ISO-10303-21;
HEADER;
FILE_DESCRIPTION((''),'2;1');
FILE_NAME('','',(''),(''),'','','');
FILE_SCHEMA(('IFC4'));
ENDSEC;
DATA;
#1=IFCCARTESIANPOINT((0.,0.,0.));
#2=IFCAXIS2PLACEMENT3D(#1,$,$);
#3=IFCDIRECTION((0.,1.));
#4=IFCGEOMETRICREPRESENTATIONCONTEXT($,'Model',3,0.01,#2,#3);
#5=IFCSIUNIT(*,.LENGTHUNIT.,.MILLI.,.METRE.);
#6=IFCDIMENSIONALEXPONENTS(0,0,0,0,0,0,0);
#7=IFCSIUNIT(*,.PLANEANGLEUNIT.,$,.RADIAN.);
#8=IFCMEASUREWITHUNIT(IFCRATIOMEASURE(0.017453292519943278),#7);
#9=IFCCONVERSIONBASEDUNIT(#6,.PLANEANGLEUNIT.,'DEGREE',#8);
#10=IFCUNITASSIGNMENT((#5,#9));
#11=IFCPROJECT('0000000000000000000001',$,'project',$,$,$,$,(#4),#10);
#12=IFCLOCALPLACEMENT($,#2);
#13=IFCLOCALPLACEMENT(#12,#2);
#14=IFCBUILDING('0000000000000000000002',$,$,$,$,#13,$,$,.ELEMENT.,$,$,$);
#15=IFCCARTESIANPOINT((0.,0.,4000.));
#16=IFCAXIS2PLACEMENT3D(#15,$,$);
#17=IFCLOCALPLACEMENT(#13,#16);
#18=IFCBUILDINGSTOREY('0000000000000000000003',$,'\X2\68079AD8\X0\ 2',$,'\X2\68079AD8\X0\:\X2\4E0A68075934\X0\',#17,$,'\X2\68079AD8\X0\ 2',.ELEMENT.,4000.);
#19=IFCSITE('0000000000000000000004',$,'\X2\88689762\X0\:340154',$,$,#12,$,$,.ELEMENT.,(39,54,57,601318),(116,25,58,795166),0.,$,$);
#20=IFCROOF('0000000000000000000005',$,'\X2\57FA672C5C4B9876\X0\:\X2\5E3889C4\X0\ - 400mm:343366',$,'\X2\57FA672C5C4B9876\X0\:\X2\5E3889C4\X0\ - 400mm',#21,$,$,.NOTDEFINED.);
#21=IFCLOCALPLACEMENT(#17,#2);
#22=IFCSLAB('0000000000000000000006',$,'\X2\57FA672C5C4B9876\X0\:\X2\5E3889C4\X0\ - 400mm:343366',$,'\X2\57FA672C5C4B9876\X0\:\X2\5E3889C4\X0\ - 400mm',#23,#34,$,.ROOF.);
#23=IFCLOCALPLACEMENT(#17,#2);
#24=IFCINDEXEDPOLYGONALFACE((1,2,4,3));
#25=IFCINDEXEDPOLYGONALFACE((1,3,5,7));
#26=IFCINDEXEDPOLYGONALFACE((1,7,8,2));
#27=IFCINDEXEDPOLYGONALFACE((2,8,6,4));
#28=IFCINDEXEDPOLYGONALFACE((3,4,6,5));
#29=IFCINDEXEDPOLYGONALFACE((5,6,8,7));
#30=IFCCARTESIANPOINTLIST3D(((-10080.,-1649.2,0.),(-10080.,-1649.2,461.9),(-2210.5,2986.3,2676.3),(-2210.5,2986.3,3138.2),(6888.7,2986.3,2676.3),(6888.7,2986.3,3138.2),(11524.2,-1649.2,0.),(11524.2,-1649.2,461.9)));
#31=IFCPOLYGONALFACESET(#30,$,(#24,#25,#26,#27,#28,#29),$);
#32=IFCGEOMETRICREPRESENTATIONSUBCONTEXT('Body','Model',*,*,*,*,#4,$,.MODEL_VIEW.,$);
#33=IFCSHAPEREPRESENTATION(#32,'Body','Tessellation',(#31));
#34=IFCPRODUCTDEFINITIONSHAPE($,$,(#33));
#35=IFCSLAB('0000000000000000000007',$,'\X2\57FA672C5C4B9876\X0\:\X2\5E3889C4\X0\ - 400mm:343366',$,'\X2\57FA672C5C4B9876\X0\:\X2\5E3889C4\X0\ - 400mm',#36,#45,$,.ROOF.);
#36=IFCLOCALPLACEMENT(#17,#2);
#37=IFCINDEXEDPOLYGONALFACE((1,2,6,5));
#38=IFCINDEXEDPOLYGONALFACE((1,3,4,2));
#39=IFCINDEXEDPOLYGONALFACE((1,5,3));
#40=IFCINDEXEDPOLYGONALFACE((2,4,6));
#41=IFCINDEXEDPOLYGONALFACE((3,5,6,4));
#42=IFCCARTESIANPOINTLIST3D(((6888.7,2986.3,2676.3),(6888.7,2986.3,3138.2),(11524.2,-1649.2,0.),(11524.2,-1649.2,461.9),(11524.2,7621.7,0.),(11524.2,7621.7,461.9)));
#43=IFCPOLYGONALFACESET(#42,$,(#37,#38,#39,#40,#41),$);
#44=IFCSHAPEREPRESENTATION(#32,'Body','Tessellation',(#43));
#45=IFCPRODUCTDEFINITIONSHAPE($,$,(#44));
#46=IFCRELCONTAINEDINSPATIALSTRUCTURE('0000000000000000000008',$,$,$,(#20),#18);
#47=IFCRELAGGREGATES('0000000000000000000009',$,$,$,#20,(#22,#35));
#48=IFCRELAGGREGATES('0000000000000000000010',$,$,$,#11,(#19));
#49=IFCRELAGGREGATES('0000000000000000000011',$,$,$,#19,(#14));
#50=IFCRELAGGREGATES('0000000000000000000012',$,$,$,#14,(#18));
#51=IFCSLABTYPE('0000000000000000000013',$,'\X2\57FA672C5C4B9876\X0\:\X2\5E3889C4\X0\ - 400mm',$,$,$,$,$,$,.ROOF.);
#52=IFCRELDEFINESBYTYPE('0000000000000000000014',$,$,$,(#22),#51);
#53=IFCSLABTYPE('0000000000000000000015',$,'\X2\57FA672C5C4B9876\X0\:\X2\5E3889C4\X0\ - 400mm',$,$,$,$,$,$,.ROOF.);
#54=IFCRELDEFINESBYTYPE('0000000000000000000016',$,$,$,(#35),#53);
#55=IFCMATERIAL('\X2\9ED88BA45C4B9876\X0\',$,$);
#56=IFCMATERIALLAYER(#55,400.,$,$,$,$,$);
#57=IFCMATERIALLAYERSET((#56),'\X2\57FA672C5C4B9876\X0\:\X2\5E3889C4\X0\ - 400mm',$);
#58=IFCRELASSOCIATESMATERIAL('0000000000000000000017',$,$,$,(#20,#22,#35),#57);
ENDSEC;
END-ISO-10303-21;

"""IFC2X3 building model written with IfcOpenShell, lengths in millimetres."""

from ifc_helpers import new_model, entity, si_unit, converted_unit, direction, frame, origin, place, context, subcontext, project, spatial, polyline, outline, extrude, material, layer, layer_set, type_object, element, aggregate, save


model = new_model("IFC2X3")

# Units and contexts
model_context = context("Model", 3, precision=0.01, world=origin(), true_north=direction((0.0, 1.0)))
body_context = subcontext(model_context, "Body", "Model", "MODEL_VIEW")
ifc_project = project(units=[si_unit("LENGTHUNIT", "METRE", prefix="MILLI"), converted_unit("PLANEANGLEUNIT", "DEGREE", entity("IfcRatioMeasure", 0.017453292519943278), si_unit("PLANEANGLEUNIT", "RADIAN"), dimensions=[0, 0, 0, 0, 0, 0, 0])], contexts=[model_context])

# Site, building, storey
site_placement = place(None, origin())
site = spatial("IfcSite", under=ifc_project, at=site_placement, Name="表面:340154", CompositionType="ELEMENT", RefLatitude=(39, 54, 57, 601318), RefLongitude=(116, 25, 58, 795166), RefElevation=0.0)
building_placement = place(site_placement, origin())
building = spatial("IfcBuilding", under=site, at=building_placement, CompositionType="ELEMENT")
storey_placement = place(building_placement, frame((0.0, 0.0, 4000.0)))
storey = spatial("IfcBuildingStorey", under=building, at=storey_placement, Name="标高 2", ObjectType="标高:上标头", LongName="标高 2", CompositionType="ELEMENT", Elevation=4000.0)

# Roof, slabs
ifc_material = material(Name="默认屋顶")
ifc_layer = layer(ifc_material, 400.0)
ifc_layer_set = layer_set([ifc_layer], Name="基本屋顶:常规 - 400mm")
roof_placement = place(storey_placement, frame((-10080.0, -1649.2, 0.0)))
roof = element("IfcRoof", 1, at=roof_placement, inside=storey, material=ifc_layer_set, Name="基本屋顶:常规 - 400mm:343366", ObjectType="基本屋顶:常规 - 400mm", ShapeType="NOTDEFINED")
slab_type_1 = type_object("IfcSlabType", Name="基本屋顶:常规 - 400mm", PredefinedType="ROOF")
slab_1_placement = place(roof_placement, origin())
slab_1 = element("IfcSlab", 2, at=slab_1_placement, type_object=slab_type_1, material=ifc_layer_set, Name="基本屋顶:常规 - 400mm:343366", ObjectType="基本屋顶:常规 - 400mm", PredefinedType="ROOF", context=body_context, shape_type="SweptSolid", body=[
    extrude(outline(polyline([(-10802.1, -2676.3), (10802.1, -2676.3), (6166.6, 2676.3), (-2932.6, 2676.3), (-10802.1, -2676.3)])), frame((10802.1, 2317.7, 1338.1), z_axis=(0.0, -0.5, 0.866025), x_axis=(1.0, 0.0, 0.0)), (0.0, 0.5, 0.866025), 461.9),
])
slab_type_2 = type_object("IfcSlabType", Name="基本屋顶:常规 - 400mm", PredefinedType="ROOF")
slab_2_placement = place(roof_placement, origin())
slab_2 = element("IfcSlab", 3, at=slab_2_placement, type_object=slab_type_2, material=ifc_layer_set, Name="基本屋顶:常规 - 400mm:343366", ObjectType="基本屋顶:常规 - 400mm", PredefinedType="ROOF", context=body_context, shape_type="SweptSolid", body=[
    extrude(outline(polyline([(2676.3, -4635.5), (2676.3, 4635.5), (-2676.3, 0.0), (2676.3, -4635.5)])), frame((19286.4, 4635.5, 1338.1), z_axis=(0.5, 0.0, 0.866025), x_axis=(0.866025, 0.0, -0.5)), (-0.5, 0.0, 0.866025), 461.9),
])
aggregate(roof, [slab_1, slab_2])

save(model, "model.ifc")
